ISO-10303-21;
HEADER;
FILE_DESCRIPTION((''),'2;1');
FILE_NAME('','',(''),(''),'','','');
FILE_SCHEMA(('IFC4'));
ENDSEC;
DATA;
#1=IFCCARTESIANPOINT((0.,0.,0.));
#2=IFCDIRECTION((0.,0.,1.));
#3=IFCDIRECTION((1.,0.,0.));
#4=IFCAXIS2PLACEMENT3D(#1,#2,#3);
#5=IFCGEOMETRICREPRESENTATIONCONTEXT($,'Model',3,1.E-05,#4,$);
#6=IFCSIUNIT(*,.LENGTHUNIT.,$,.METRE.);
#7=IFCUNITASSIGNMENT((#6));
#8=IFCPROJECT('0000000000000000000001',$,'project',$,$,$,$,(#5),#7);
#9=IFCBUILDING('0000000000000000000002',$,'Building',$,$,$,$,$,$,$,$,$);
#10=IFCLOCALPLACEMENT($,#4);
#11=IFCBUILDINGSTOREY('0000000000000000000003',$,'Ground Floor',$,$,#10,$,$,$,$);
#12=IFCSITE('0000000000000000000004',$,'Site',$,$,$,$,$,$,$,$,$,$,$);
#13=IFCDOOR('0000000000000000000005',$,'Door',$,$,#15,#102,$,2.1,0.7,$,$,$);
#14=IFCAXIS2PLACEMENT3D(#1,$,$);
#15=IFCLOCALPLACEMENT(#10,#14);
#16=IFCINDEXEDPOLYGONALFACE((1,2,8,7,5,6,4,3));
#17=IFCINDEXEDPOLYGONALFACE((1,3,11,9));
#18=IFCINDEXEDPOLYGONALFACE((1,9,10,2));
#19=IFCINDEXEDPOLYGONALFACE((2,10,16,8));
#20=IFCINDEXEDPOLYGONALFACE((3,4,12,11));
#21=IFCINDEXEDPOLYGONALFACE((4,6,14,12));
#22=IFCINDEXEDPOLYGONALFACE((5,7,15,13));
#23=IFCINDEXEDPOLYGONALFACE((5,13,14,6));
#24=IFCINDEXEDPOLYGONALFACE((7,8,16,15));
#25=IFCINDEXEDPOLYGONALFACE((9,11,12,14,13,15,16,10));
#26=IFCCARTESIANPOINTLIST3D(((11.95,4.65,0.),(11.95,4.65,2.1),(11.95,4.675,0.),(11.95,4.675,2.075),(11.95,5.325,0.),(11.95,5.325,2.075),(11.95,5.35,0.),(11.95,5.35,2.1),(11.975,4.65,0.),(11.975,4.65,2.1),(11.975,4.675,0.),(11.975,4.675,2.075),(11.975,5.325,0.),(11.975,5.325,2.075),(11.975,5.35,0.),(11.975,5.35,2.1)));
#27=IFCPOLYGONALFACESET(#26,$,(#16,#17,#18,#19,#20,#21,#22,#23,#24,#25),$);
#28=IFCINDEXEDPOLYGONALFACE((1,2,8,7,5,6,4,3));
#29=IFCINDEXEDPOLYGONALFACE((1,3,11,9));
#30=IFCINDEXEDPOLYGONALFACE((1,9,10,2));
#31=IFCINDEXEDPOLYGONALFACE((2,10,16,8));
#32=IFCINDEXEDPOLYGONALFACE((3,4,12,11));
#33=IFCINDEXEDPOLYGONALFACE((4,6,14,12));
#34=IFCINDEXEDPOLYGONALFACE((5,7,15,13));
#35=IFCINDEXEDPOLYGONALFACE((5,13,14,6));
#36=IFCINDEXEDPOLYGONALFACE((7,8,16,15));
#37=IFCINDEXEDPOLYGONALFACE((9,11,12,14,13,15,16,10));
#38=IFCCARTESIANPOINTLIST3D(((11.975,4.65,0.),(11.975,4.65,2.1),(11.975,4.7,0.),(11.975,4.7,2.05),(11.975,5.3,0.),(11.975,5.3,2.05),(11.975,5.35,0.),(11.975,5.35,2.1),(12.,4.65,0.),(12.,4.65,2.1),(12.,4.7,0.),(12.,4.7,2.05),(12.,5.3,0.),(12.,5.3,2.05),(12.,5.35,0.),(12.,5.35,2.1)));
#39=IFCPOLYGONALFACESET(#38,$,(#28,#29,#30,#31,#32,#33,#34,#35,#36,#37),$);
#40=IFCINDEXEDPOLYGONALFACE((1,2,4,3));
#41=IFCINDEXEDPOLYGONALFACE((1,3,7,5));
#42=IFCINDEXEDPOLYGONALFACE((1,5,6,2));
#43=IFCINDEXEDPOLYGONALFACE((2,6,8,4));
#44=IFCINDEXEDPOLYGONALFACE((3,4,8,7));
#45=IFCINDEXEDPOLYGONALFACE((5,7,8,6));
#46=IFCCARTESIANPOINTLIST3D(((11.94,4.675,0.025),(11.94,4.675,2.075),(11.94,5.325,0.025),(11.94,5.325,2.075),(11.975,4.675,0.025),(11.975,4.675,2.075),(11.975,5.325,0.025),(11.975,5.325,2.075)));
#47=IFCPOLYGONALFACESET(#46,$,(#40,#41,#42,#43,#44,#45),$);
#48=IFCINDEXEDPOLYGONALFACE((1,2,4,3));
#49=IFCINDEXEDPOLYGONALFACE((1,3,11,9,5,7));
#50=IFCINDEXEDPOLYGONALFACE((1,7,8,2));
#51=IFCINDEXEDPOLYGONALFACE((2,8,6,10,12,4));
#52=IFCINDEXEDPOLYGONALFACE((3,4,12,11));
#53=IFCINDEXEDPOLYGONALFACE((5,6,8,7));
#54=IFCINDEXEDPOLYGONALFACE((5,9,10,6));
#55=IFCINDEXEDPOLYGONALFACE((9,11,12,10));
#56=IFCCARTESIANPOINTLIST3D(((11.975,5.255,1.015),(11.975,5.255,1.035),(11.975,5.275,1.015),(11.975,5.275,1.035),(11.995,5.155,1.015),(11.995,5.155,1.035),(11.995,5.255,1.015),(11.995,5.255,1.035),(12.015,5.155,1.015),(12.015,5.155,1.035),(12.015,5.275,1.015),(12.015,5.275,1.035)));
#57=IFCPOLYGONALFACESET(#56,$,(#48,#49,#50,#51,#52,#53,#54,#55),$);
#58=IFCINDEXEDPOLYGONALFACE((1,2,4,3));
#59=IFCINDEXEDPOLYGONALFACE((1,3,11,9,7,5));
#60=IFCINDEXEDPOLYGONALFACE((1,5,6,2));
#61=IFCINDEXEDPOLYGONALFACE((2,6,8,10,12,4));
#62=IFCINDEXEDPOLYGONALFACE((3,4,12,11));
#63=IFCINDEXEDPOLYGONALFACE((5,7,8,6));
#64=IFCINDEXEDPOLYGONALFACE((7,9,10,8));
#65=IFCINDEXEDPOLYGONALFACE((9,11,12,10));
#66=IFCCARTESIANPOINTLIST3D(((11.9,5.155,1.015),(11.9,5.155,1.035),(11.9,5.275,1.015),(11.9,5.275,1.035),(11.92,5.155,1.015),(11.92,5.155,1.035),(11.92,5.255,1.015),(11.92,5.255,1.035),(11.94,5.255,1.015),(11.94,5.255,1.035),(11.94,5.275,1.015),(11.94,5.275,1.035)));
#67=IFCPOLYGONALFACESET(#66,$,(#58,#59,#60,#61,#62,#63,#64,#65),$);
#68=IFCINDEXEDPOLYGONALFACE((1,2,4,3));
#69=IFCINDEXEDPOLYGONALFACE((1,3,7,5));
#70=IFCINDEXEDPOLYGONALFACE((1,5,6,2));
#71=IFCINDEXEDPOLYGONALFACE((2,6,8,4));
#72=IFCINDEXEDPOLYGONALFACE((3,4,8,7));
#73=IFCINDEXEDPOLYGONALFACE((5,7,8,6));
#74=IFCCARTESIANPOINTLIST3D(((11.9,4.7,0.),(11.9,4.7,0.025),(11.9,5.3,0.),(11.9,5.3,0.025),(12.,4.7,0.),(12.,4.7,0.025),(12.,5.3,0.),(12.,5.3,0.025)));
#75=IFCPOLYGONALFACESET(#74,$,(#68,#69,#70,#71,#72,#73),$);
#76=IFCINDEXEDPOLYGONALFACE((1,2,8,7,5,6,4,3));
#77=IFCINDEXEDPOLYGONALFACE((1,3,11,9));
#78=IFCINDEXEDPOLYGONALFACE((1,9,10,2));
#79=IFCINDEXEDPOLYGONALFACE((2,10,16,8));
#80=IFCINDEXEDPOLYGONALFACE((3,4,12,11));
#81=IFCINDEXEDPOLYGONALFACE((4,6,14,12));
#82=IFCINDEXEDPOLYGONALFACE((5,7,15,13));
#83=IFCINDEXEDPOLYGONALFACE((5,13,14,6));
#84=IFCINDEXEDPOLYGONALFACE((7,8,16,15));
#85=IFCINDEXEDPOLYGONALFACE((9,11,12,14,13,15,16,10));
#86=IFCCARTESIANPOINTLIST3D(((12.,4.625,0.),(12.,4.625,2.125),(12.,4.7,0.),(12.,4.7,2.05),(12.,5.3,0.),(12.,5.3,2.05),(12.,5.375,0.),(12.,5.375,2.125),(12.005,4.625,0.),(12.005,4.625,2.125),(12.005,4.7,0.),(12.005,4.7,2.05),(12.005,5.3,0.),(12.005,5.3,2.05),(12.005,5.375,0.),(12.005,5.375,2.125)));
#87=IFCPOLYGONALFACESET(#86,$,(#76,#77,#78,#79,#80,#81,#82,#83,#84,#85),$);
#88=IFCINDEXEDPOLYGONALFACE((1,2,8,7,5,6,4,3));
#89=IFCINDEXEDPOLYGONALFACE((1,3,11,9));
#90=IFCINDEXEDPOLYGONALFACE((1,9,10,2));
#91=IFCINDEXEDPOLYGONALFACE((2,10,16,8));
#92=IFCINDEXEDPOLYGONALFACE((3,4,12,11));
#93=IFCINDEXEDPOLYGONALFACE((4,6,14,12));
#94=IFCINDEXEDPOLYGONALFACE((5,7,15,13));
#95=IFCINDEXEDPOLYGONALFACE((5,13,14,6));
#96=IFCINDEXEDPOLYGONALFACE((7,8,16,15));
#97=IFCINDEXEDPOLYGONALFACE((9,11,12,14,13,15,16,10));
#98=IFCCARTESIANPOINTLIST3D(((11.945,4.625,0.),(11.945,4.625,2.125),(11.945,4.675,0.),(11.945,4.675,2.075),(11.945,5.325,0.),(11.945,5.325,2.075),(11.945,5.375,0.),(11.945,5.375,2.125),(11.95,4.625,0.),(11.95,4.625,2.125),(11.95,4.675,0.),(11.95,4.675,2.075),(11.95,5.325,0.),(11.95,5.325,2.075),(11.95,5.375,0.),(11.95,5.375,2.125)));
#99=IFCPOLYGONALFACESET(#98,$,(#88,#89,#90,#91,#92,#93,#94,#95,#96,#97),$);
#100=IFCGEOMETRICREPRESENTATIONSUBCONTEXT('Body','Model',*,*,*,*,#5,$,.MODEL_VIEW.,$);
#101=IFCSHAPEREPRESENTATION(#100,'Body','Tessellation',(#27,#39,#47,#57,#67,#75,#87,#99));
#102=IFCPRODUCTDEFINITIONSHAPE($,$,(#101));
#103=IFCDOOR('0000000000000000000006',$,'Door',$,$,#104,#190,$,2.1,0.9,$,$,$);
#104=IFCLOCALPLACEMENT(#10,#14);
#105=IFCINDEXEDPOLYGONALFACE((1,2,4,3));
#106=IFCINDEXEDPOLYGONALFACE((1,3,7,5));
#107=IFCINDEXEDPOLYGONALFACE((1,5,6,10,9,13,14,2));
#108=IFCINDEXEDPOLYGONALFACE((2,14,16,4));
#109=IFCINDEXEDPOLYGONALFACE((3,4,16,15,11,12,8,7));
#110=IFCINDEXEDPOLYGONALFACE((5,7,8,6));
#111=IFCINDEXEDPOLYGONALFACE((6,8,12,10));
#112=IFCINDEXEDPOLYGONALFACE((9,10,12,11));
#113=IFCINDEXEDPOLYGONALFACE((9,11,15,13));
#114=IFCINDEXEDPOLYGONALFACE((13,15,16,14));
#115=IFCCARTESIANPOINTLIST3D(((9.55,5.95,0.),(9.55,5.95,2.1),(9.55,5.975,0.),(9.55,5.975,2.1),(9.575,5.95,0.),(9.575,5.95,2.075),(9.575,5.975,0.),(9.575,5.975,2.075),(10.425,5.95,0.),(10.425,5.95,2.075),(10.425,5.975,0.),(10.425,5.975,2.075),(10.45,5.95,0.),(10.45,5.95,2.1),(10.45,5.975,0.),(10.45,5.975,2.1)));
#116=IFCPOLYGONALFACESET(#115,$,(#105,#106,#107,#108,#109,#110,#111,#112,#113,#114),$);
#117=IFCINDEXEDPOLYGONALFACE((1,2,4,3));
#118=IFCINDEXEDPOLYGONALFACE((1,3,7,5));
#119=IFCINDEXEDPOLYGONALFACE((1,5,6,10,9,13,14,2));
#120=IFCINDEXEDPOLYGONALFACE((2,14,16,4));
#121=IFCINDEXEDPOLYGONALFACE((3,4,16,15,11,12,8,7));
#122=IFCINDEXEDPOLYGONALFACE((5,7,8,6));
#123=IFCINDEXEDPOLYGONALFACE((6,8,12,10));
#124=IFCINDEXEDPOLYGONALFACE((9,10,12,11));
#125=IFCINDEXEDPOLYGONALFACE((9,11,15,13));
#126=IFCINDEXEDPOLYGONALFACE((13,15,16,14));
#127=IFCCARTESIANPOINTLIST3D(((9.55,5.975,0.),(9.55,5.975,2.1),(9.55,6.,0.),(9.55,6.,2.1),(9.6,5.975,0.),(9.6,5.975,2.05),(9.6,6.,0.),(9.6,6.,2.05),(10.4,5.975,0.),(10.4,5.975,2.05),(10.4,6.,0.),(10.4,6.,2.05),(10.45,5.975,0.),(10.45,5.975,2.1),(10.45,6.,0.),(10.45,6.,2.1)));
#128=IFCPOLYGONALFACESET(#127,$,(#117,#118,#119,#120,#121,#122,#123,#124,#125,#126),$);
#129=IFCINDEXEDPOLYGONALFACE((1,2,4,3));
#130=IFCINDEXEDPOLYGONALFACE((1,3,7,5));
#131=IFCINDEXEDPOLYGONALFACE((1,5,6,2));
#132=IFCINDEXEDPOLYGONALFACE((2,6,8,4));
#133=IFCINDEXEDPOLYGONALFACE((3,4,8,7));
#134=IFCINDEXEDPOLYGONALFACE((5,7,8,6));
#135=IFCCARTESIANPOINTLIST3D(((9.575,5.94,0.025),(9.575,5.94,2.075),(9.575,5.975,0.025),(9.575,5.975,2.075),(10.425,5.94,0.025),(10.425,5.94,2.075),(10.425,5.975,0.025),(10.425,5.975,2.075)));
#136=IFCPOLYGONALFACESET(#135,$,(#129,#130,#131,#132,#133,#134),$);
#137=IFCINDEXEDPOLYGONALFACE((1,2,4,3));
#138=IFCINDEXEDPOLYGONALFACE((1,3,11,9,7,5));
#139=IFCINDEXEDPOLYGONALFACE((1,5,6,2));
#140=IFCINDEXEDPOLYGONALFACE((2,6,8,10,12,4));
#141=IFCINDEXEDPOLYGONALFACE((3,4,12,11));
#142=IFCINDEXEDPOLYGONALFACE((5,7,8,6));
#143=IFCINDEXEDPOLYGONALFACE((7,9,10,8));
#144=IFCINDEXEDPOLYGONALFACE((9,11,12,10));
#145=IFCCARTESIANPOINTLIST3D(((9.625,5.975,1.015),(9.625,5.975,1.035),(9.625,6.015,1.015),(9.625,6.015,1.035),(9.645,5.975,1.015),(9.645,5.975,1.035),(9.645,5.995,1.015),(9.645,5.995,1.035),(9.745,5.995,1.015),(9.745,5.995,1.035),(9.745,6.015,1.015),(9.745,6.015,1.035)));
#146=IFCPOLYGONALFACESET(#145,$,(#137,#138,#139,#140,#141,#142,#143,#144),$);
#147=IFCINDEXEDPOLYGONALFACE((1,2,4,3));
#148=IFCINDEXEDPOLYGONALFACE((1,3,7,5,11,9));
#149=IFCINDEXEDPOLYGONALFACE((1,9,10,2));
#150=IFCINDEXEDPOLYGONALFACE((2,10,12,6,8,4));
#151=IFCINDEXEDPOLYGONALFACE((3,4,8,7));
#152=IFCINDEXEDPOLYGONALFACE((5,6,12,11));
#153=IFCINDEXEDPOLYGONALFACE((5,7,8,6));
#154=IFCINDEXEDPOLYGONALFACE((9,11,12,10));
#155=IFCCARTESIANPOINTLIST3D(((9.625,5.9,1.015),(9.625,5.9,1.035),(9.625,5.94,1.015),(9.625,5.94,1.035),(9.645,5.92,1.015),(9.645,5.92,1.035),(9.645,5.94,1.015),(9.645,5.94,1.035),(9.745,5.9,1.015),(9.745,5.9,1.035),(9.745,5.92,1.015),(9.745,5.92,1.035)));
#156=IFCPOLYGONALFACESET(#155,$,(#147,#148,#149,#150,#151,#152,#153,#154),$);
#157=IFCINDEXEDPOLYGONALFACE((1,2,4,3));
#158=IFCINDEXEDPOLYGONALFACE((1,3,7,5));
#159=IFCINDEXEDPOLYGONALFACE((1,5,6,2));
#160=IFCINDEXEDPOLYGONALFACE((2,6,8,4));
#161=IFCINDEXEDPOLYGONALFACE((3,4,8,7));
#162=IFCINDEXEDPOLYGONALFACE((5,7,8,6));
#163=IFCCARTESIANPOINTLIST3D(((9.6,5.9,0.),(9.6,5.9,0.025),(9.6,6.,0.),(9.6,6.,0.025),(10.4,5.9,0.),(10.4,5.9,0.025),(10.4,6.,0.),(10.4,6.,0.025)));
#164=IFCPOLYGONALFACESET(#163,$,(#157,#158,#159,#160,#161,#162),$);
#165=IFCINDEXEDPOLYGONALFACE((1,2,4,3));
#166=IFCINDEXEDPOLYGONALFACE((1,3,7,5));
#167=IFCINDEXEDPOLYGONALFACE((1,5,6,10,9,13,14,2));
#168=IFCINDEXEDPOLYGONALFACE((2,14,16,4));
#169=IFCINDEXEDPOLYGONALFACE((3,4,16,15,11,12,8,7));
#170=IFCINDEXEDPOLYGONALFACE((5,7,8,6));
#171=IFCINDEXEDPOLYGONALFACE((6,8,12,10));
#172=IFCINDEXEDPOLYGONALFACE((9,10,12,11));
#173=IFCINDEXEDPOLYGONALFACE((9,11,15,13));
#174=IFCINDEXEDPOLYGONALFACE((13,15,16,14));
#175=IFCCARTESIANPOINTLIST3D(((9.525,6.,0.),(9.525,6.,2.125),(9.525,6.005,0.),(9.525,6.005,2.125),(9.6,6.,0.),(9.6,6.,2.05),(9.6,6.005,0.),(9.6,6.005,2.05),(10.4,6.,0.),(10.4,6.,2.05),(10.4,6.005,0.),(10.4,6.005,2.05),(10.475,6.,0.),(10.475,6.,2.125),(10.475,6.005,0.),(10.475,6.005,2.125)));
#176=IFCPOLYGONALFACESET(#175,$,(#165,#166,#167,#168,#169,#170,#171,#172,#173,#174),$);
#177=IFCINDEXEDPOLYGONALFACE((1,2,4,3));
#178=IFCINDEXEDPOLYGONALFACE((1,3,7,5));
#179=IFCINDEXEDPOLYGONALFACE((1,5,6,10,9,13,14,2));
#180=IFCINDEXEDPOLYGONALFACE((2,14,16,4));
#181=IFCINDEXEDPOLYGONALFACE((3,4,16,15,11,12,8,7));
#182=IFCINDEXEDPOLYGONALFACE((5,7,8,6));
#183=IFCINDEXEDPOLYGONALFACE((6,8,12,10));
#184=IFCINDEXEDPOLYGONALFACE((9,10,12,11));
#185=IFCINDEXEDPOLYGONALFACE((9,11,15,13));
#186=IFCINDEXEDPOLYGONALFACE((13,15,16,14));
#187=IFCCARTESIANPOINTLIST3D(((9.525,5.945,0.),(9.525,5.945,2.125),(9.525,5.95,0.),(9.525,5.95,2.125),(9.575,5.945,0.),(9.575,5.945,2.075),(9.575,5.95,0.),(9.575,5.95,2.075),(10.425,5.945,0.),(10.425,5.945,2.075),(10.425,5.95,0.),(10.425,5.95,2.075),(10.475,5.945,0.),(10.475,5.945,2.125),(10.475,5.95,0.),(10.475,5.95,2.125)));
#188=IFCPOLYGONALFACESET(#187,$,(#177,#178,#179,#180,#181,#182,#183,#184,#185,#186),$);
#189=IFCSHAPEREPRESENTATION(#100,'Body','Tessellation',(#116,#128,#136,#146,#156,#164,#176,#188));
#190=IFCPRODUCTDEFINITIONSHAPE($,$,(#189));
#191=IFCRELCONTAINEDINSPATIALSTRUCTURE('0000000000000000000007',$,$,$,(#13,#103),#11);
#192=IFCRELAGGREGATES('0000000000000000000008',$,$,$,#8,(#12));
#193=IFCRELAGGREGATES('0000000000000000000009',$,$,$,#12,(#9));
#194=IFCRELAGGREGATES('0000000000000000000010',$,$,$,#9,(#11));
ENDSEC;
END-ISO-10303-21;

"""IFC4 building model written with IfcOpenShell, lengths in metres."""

from ifc_helpers import new_model, si_unit, frame, origin_with_axes, place, context, subcontext, project, spatial, line, indexed_curve, outline, extrude, element, save


model = new_model("IFC4")

# Units and contexts
model_context = context("Model", 3, precision=1e-05, world=origin_with_axes())
body_context = subcontext(model_context, "Body", "Model", "MODEL_VIEW")
ifc_project = project(units=[si_unit("LENGTHUNIT", "METRE")], contexts=[model_context])

# Site, building, storey
site = spatial("IfcSite", under=ifc_project, Name="Site")
building = spatial("IfcBuilding", under=site, Name="Building")
storey_placement = place(None, origin_with_axes())
storey = spatial("IfcBuildingStorey", under=building, at=storey_placement, Name="Ground Floor")

# Doors
door_1_placement = place(storey_placement, frame((12.0, 4.65, 0.0), z_axis=(0.0, 0.0, 1.0), x_axis=(0.0, 1.0, 0.0)))
element("IfcDoor", 1, at=door_1_placement, inside=storey, Name="Door", OverallHeight=2.1, OverallWidth=0.7, context=body_context, shape_type="SweptSolid", body=[
    extrude(outline(indexed_curve([(0.0, 0.0), (0.0, 2.1), (0.7, 2.1), (0.7, 0.0), (0.675, 0.0), (0.675, 2.075), (0.025, 2.075), (0.025, 0.0)], segments=[line(1, 2, 3, 4, 5, 6, 7, 8, 1)])), frame((0.0, 0.025, 0.0), z_axis=(0.0, -1.0, 0.0), x_axis=(1.0, 0.0, 0.0)), (0.0, 0.0, -1.0), 0.025),
    extrude(outline(indexed_curve([(0.0, 0.0), (0.0, 2.1), (0.7, 2.1), (0.7, 0.0), (0.65, 0.0), (0.65, 2.05), (0.05, 2.05), (0.05, 0.0)], segments=[line(1, 2, 3, 4, 5, 6, 7, 8, 1)])), frame((0.0, 0.0, 0.0), z_axis=(0.0, -1.0, 0.0), x_axis=(1.0, 0.0, 0.0)), (0.0, 0.0, -1.0), 0.025),
    extrude(outline(indexed_curve([(0.0, 0.0), (0.65, 0.0), (0.65, 0.035), (0.0, 0.035)], segments=[line(1, 2, 3, 4, 1)])), frame((0.025, 0.025, 0.025), z_axis=(0.0, 0.0, 1.0), x_axis=(1.0, 0.0, 0.0)), (0.0, 0.0, 1.0), 2.05),
    extrude(outline(indexed_curve([(0.0, 0.0), (0.0, -0.04), (-0.12, -0.04), (-0.12, -0.02), (-0.02, -0.02), (-0.02, 0.0)], segments=[line(1, 2, 3, 4, 5, 6, 1)])), frame((0.625, 0.025, 1.015), z_axis=(0.0, 0.0, 1.0), x_axis=(1.0, 0.0, 0.0)), (0.0, 0.0, 1.0), 0.02),
    extrude(outline(indexed_curve([(0.0, 0.0), (0.0, 0.04), (-0.12, 0.04), (-0.12, 0.02), (-0.02, 0.02), (-0.02, 0.0)], segments=[line(1, 2, 3, 4, 5, 6, 1)])), frame((0.625, 0.06, 1.015), z_axis=(0.0, 0.0, 1.0), x_axis=(1.0, 0.0, 0.0)), (0.0, 0.0, 1.0), 0.02),
    extrude(outline(indexed_curve([(0.0, 0.0), (0.6, 0.0), (0.6, 0.1), (0.0, 0.1)], segments=[line(1, 2, 3, 4, 1)])), frame((0.05, 0.0, 0.0), z_axis=(0.0, 0.0, 1.0), x_axis=(1.0, 0.0, 0.0)), (0.0, 0.0, 1.0), 0.025),
    extrude(outline(indexed_curve([(0.0, 0.0), (0.0, 2.125), (0.75, 2.125), (0.75, 0.0), (0.675, 0.0), (0.675, 2.05), (0.075, 2.05), (0.075, 0.0)], segments=[line(1, 2, 3, 4, 5, 6, 7, 8, 1)])), frame((-0.025, -0.005, 0.0), z_axis=(0.0, -1.0, 0.0), x_axis=(1.0, 0.0, 0.0)), (0.0, 0.0, -1.0), 0.005),
    extrude(outline(indexed_curve([(0.0, 0.0), (0.0, 2.125), (0.75, 2.125), (0.75, 0.0), (0.7, 0.0), (0.7, 2.075), (0.05, 2.075), (0.05, 0.0)], segments=[line(1, 2, 3, 4, 5, 6, 7, 8, 1)])), frame((-0.025, 0.05, 0.0), z_axis=(0.0, -1.0, 0.0), x_axis=(1.0, 0.0, 0.0)), (0.0, 0.0, -1.0), 0.005),
])
door_2_placement = place(storey_placement, frame((10.45, 6.0, 0.0), z_axis=(0.0, 0.0, 1.0), x_axis=(-1.0, 0.0, 0.0)))
element("IfcDoor", 2, at=door_2_placement, inside=storey, Name="Door", OverallHeight=2.1, OverallWidth=0.9, context=body_context, shape_type="SweptSolid", body=[
    extrude(outline(indexed_curve([(0.0, 0.0), (0.0, 2.1), (0.9, 2.1), (0.9, 0.0), (0.875, 0.0), (0.875, 2.075), (0.025, 2.075), (0.025, 0.0)], segments=[line(1, 2, 3, 4, 5, 6, 7, 8, 1)])), frame((0.0, 0.025, 0.0), z_axis=(0.0, -1.0, 0.0), x_axis=(1.0, 0.0, 0.0)), (0.0, 0.0, -1.0), 0.025),
    extrude(outline(indexed_curve([(0.0, 0.0), (0.0, 2.1), (0.9, 2.1), (0.9, 0.0), (0.85, 0.0), (0.85, 2.05), (0.05, 2.05), (0.05, 0.0)], segments=[line(1, 2, 3, 4, 5, 6, 7, 8, 1)])), frame((0.0, 0.0, 0.0), z_axis=(0.0, -1.0, 0.0), x_axis=(1.0, 0.0, 0.0)), (0.0, 0.0, -1.0), 0.025),
    extrude(outline(indexed_curve([(0.0, 0.0), (0.85, 0.0), (0.85, 0.035), (0.0, 0.035)], segments=[line(1, 2, 3, 4, 1)])), frame((0.025, 0.025, 0.025), z_axis=(0.0, 0.0, 1.0), x_axis=(1.0, 0.0, 0.0)), (0.0, 0.0, 1.0), 2.05),
    extrude(outline(indexed_curve([(0.0, 0.0), (0.0, -0.04), (-0.12, -0.04), (-0.12, -0.02), (-0.02, -0.02), (-0.02, 0.0)], segments=[line(1, 2, 3, 4, 5, 6, 1)])), frame((0.825, 0.025, 1.015), z_axis=(0.0, 0.0, 1.0), x_axis=(1.0, 0.0, 0.0)), (0.0, 0.0, 1.0), 0.02),
    extrude(outline(indexed_curve([(0.0, 0.0), (0.0, 0.04), (-0.12, 0.04), (-0.12, 0.02), (-0.02, 0.02), (-0.02, 0.0)], segments=[line(1, 2, 3, 4, 5, 6, 1)])), frame((0.825, 0.06, 1.015), z_axis=(0.0, 0.0, 1.0), x_axis=(1.0, 0.0, 0.0)), (0.0, 0.0, 1.0), 0.02),
    extrude(outline(indexed_curve([(0.0, 0.0), (0.8, 0.0), (0.8, 0.1), (0.0, 0.1)], segments=[line(1, 2, 3, 4, 1)])), frame((0.05, 0.0, 0.0), z_axis=(0.0, 0.0, 1.0), x_axis=(1.0, 0.0, 0.0)), (0.0, 0.0, 1.0), 0.025),
    extrude(outline(indexed_curve([(0.0, 0.0), (0.0, 2.125), (0.95, 2.125), (0.95, 0.0), (0.875, 0.0), (0.875, 2.05), (0.075, 2.05), (0.075, 0.0)], segments=[line(1, 2, 3, 4, 5, 6, 7, 8, 1)])), frame((-0.025, -0.005, 0.0), z_axis=(0.0, -1.0, 0.0), x_axis=(1.0, 0.0, 0.0)), (0.0, 0.0, -1.0), 0.005),
    extrude(outline(indexed_curve([(0.0, 0.0), (0.0, 2.125), (0.95, 2.125), (0.95, 0.0), (0.9, 0.0), (0.9, 2.075), (0.05, 2.075), (0.05, 0.0)], segments=[line(1, 2, 3, 4, 5, 6, 7, 8, 1)])), frame((-0.025, 0.05, 0.0), z_axis=(0.0, -1.0, 0.0), x_axis=(1.0, 0.0, 0.0)), (0.0, 0.0, -1.0), 0.005),
])

save(model, "model.ifc")
